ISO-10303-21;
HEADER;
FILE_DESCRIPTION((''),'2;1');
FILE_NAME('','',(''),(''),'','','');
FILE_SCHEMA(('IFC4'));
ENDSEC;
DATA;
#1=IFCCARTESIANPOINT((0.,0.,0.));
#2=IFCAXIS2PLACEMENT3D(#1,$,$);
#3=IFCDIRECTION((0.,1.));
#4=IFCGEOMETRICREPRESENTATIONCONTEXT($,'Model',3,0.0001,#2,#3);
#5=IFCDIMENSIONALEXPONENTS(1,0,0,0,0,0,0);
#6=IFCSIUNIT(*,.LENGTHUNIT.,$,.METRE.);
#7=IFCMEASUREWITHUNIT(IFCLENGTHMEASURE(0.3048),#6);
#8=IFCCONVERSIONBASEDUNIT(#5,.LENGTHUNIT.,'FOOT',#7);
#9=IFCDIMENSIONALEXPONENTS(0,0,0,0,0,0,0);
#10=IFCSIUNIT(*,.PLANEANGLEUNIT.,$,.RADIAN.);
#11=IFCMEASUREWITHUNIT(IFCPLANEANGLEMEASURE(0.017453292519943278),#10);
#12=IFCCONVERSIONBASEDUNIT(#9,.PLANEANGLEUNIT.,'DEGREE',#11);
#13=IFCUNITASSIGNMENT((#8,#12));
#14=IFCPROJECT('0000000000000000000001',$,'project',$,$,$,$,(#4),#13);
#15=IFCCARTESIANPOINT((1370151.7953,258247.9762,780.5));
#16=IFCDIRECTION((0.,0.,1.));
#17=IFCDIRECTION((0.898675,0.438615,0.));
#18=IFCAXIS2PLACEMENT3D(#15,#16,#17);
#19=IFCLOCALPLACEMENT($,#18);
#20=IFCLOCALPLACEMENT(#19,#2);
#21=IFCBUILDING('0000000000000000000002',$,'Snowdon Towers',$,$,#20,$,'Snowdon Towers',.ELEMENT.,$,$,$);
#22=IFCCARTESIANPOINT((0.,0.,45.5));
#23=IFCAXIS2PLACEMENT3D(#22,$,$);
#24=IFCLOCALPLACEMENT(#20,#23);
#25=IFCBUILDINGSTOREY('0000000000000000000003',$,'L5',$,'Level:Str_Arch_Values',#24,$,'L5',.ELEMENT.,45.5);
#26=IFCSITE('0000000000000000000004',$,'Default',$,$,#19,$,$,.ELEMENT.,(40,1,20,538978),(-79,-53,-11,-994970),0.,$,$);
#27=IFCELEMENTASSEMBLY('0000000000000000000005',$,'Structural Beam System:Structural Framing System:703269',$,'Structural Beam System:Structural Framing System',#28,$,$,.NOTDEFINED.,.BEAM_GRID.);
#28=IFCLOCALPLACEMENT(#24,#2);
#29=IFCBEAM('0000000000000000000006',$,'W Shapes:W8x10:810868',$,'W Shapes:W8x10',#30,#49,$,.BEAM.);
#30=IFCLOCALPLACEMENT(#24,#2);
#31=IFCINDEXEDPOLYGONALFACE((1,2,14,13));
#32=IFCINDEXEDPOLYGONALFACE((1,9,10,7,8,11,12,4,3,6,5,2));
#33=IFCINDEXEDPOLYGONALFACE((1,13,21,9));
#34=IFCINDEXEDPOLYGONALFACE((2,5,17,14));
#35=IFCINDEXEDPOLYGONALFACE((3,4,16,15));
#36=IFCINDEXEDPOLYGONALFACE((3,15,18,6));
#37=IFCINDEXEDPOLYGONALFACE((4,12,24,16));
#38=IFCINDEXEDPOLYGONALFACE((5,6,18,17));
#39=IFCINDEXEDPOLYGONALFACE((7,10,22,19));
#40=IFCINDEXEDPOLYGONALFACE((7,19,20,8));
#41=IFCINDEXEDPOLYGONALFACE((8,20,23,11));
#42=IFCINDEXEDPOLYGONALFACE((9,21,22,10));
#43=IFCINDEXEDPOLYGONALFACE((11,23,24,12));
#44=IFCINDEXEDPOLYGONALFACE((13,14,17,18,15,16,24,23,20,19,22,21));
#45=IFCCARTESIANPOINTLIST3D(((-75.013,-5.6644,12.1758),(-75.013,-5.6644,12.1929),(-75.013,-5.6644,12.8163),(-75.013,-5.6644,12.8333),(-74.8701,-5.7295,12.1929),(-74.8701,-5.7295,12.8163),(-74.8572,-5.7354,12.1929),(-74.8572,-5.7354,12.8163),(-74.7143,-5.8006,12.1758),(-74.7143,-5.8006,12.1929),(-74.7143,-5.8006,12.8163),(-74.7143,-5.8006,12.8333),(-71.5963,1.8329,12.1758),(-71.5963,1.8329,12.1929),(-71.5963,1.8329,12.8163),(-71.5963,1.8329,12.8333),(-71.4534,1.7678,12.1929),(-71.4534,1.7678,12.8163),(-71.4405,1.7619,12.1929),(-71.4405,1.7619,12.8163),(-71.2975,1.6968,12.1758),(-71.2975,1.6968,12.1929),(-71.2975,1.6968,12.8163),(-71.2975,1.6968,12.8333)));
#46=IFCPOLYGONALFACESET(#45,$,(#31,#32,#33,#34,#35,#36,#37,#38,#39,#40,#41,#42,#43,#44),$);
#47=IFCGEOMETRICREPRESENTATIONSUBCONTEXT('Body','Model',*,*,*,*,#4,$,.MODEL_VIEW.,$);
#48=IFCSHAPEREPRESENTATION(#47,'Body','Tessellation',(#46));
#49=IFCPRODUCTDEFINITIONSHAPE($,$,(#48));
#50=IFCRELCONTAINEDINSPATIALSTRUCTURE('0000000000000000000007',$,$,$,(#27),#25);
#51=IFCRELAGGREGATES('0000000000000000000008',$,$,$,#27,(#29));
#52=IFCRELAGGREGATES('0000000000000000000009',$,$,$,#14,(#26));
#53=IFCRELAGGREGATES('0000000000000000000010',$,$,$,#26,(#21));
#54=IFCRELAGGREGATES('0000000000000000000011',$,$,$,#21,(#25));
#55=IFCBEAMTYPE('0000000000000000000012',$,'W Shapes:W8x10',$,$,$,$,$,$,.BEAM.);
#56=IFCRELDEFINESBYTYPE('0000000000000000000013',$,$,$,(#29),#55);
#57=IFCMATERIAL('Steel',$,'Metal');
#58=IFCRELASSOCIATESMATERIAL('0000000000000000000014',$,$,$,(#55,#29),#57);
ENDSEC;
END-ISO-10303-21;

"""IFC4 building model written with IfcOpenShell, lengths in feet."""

from ifc_helpers import new_model, entity, si_unit, converted_unit, direction, frame, origin, place, context, subcontext, project, spatial, indexed_curve, outline, extrude, source, transform, mapped, material, type_object, type_shapes, element, aggregate, save


model = new_model("IFC4")

# Units and contexts
model_context = context("Model", 3, precision=0.0001, world=origin(), true_north=direction((0.0, 1.0)))
body_context = subcontext(model_context, "Body", "Model", "MODEL_VIEW")
ifc_project = project(units=[converted_unit("LENGTHUNIT", "FOOT", entity("IfcLengthMeasure", 0.3048), si_unit("LENGTHUNIT", "METRE"), dimensions=[1, 0, 0, 0, 0, 0, 0]), converted_unit("PLANEANGLEUNIT", "DEGREE", entity("IfcPlaneAngleMeasure", 0.017453292519943278), si_unit("PLANEANGLEUNIT", "RADIAN"), dimensions=[0, 0, 0, 0, 0, 0, 0])], contexts=[model_context])

# Site, building, storey
site_placement = place(None, frame((1370151.7953, 258247.9762, 780.5), z_axis=(0.0, 0.0, 1.0), x_axis=(0.898675, 0.438615, 0.0)))
site = spatial("IfcSite", under=ifc_project, at=site_placement, Name="Default", CompositionType="ELEMENT", RefLatitude=(40, 1, 20, 538978), RefLongitude=(-79, -53, -11, -994970), RefElevation=0.0)
building_placement = place(site_placement, origin())
building = spatial("IfcBuilding", under=site, at=building_placement, Name="Snowdon Towers", LongName="Snowdon Towers", CompositionType="ELEMENT")
storey_placement = place(building_placement, frame((0.0, 0.0, 45.5)))
storey = spatial("IfcBuildingStorey", under=building, at=storey_placement, Name="L5", ObjectType="Level:Str_Arch_Values", LongName="L5", CompositionType="ELEMENT", Elevation=45.5)

# Shared definitions
ifc_material = material(Name="Steel", Category="Metal")

# Element assembly, beam
assembly_1_placement = place(storey_placement, origin())
assembly_1 = element("IfcElementAssembly", 1, at=assembly_1_placement, inside=storey, Name="Structural Beam System:Structural Framing System:703269", ObjectType="Structural Beam System:Structural Framing System", AssemblyPlace="NOTDEFINED", PredefinedType="BEAM_GRID")
beam_type_1 = type_object("IfcBeamType", Name="W Shapes:W8x10", PredefinedType="BEAM", material=ifc_material)
shared_shape_1 = source(origin(), body_context, "Body", "SweptSolid", [
    extrude(outline(indexed_curve([(-0.1642, -0.3117), (-0.1642, -0.3288), (0.1642, -0.3288), (0.1642, -0.3117), (0.0071, -0.3117), (0.0071, 0.3117), (0.1642, 0.3117), (0.1642, 0.3287), (-0.1642, 0.3287), (-0.1642, 0.3117), (-0.0071, 0.3117), (-0.0071, -0.3117), (-0.1642, -0.3117)], self_intersect=False)), frame((-4.3675, 0.0, 0.0), z_axis=(-1.0, 0.0, 0.0), x_axis=(0.0, -1.0, 0.0)), (0.0, 0.0, -1.0), 8.2392),
])
type_shapes(beam_type_1, [shared_shape_1])
beam_1_placement = place(assembly_1_placement, frame((-73.0525, -1.7582, 12.5046), z_axis=(0.0, 0.0, 1.0), x_axis=(0.414693, 0.909961, 0.0)))
beam_1 = element("IfcBeam", 2, at=beam_1_placement, type_object=beam_type_1, material=ifc_material, Name="W Shapes:W8x10:810868", ObjectType="W Shapes:W8x10", PredefinedType="BEAM", context=body_context, shape_type="MappedRepresentation", body=[
    mapped(shared_shape_1, transform((0.0, 0.0, 0.0), scale=1.0)),
])
aggregate(assembly_1, [beam_1])

save(model, "model.ifc")
